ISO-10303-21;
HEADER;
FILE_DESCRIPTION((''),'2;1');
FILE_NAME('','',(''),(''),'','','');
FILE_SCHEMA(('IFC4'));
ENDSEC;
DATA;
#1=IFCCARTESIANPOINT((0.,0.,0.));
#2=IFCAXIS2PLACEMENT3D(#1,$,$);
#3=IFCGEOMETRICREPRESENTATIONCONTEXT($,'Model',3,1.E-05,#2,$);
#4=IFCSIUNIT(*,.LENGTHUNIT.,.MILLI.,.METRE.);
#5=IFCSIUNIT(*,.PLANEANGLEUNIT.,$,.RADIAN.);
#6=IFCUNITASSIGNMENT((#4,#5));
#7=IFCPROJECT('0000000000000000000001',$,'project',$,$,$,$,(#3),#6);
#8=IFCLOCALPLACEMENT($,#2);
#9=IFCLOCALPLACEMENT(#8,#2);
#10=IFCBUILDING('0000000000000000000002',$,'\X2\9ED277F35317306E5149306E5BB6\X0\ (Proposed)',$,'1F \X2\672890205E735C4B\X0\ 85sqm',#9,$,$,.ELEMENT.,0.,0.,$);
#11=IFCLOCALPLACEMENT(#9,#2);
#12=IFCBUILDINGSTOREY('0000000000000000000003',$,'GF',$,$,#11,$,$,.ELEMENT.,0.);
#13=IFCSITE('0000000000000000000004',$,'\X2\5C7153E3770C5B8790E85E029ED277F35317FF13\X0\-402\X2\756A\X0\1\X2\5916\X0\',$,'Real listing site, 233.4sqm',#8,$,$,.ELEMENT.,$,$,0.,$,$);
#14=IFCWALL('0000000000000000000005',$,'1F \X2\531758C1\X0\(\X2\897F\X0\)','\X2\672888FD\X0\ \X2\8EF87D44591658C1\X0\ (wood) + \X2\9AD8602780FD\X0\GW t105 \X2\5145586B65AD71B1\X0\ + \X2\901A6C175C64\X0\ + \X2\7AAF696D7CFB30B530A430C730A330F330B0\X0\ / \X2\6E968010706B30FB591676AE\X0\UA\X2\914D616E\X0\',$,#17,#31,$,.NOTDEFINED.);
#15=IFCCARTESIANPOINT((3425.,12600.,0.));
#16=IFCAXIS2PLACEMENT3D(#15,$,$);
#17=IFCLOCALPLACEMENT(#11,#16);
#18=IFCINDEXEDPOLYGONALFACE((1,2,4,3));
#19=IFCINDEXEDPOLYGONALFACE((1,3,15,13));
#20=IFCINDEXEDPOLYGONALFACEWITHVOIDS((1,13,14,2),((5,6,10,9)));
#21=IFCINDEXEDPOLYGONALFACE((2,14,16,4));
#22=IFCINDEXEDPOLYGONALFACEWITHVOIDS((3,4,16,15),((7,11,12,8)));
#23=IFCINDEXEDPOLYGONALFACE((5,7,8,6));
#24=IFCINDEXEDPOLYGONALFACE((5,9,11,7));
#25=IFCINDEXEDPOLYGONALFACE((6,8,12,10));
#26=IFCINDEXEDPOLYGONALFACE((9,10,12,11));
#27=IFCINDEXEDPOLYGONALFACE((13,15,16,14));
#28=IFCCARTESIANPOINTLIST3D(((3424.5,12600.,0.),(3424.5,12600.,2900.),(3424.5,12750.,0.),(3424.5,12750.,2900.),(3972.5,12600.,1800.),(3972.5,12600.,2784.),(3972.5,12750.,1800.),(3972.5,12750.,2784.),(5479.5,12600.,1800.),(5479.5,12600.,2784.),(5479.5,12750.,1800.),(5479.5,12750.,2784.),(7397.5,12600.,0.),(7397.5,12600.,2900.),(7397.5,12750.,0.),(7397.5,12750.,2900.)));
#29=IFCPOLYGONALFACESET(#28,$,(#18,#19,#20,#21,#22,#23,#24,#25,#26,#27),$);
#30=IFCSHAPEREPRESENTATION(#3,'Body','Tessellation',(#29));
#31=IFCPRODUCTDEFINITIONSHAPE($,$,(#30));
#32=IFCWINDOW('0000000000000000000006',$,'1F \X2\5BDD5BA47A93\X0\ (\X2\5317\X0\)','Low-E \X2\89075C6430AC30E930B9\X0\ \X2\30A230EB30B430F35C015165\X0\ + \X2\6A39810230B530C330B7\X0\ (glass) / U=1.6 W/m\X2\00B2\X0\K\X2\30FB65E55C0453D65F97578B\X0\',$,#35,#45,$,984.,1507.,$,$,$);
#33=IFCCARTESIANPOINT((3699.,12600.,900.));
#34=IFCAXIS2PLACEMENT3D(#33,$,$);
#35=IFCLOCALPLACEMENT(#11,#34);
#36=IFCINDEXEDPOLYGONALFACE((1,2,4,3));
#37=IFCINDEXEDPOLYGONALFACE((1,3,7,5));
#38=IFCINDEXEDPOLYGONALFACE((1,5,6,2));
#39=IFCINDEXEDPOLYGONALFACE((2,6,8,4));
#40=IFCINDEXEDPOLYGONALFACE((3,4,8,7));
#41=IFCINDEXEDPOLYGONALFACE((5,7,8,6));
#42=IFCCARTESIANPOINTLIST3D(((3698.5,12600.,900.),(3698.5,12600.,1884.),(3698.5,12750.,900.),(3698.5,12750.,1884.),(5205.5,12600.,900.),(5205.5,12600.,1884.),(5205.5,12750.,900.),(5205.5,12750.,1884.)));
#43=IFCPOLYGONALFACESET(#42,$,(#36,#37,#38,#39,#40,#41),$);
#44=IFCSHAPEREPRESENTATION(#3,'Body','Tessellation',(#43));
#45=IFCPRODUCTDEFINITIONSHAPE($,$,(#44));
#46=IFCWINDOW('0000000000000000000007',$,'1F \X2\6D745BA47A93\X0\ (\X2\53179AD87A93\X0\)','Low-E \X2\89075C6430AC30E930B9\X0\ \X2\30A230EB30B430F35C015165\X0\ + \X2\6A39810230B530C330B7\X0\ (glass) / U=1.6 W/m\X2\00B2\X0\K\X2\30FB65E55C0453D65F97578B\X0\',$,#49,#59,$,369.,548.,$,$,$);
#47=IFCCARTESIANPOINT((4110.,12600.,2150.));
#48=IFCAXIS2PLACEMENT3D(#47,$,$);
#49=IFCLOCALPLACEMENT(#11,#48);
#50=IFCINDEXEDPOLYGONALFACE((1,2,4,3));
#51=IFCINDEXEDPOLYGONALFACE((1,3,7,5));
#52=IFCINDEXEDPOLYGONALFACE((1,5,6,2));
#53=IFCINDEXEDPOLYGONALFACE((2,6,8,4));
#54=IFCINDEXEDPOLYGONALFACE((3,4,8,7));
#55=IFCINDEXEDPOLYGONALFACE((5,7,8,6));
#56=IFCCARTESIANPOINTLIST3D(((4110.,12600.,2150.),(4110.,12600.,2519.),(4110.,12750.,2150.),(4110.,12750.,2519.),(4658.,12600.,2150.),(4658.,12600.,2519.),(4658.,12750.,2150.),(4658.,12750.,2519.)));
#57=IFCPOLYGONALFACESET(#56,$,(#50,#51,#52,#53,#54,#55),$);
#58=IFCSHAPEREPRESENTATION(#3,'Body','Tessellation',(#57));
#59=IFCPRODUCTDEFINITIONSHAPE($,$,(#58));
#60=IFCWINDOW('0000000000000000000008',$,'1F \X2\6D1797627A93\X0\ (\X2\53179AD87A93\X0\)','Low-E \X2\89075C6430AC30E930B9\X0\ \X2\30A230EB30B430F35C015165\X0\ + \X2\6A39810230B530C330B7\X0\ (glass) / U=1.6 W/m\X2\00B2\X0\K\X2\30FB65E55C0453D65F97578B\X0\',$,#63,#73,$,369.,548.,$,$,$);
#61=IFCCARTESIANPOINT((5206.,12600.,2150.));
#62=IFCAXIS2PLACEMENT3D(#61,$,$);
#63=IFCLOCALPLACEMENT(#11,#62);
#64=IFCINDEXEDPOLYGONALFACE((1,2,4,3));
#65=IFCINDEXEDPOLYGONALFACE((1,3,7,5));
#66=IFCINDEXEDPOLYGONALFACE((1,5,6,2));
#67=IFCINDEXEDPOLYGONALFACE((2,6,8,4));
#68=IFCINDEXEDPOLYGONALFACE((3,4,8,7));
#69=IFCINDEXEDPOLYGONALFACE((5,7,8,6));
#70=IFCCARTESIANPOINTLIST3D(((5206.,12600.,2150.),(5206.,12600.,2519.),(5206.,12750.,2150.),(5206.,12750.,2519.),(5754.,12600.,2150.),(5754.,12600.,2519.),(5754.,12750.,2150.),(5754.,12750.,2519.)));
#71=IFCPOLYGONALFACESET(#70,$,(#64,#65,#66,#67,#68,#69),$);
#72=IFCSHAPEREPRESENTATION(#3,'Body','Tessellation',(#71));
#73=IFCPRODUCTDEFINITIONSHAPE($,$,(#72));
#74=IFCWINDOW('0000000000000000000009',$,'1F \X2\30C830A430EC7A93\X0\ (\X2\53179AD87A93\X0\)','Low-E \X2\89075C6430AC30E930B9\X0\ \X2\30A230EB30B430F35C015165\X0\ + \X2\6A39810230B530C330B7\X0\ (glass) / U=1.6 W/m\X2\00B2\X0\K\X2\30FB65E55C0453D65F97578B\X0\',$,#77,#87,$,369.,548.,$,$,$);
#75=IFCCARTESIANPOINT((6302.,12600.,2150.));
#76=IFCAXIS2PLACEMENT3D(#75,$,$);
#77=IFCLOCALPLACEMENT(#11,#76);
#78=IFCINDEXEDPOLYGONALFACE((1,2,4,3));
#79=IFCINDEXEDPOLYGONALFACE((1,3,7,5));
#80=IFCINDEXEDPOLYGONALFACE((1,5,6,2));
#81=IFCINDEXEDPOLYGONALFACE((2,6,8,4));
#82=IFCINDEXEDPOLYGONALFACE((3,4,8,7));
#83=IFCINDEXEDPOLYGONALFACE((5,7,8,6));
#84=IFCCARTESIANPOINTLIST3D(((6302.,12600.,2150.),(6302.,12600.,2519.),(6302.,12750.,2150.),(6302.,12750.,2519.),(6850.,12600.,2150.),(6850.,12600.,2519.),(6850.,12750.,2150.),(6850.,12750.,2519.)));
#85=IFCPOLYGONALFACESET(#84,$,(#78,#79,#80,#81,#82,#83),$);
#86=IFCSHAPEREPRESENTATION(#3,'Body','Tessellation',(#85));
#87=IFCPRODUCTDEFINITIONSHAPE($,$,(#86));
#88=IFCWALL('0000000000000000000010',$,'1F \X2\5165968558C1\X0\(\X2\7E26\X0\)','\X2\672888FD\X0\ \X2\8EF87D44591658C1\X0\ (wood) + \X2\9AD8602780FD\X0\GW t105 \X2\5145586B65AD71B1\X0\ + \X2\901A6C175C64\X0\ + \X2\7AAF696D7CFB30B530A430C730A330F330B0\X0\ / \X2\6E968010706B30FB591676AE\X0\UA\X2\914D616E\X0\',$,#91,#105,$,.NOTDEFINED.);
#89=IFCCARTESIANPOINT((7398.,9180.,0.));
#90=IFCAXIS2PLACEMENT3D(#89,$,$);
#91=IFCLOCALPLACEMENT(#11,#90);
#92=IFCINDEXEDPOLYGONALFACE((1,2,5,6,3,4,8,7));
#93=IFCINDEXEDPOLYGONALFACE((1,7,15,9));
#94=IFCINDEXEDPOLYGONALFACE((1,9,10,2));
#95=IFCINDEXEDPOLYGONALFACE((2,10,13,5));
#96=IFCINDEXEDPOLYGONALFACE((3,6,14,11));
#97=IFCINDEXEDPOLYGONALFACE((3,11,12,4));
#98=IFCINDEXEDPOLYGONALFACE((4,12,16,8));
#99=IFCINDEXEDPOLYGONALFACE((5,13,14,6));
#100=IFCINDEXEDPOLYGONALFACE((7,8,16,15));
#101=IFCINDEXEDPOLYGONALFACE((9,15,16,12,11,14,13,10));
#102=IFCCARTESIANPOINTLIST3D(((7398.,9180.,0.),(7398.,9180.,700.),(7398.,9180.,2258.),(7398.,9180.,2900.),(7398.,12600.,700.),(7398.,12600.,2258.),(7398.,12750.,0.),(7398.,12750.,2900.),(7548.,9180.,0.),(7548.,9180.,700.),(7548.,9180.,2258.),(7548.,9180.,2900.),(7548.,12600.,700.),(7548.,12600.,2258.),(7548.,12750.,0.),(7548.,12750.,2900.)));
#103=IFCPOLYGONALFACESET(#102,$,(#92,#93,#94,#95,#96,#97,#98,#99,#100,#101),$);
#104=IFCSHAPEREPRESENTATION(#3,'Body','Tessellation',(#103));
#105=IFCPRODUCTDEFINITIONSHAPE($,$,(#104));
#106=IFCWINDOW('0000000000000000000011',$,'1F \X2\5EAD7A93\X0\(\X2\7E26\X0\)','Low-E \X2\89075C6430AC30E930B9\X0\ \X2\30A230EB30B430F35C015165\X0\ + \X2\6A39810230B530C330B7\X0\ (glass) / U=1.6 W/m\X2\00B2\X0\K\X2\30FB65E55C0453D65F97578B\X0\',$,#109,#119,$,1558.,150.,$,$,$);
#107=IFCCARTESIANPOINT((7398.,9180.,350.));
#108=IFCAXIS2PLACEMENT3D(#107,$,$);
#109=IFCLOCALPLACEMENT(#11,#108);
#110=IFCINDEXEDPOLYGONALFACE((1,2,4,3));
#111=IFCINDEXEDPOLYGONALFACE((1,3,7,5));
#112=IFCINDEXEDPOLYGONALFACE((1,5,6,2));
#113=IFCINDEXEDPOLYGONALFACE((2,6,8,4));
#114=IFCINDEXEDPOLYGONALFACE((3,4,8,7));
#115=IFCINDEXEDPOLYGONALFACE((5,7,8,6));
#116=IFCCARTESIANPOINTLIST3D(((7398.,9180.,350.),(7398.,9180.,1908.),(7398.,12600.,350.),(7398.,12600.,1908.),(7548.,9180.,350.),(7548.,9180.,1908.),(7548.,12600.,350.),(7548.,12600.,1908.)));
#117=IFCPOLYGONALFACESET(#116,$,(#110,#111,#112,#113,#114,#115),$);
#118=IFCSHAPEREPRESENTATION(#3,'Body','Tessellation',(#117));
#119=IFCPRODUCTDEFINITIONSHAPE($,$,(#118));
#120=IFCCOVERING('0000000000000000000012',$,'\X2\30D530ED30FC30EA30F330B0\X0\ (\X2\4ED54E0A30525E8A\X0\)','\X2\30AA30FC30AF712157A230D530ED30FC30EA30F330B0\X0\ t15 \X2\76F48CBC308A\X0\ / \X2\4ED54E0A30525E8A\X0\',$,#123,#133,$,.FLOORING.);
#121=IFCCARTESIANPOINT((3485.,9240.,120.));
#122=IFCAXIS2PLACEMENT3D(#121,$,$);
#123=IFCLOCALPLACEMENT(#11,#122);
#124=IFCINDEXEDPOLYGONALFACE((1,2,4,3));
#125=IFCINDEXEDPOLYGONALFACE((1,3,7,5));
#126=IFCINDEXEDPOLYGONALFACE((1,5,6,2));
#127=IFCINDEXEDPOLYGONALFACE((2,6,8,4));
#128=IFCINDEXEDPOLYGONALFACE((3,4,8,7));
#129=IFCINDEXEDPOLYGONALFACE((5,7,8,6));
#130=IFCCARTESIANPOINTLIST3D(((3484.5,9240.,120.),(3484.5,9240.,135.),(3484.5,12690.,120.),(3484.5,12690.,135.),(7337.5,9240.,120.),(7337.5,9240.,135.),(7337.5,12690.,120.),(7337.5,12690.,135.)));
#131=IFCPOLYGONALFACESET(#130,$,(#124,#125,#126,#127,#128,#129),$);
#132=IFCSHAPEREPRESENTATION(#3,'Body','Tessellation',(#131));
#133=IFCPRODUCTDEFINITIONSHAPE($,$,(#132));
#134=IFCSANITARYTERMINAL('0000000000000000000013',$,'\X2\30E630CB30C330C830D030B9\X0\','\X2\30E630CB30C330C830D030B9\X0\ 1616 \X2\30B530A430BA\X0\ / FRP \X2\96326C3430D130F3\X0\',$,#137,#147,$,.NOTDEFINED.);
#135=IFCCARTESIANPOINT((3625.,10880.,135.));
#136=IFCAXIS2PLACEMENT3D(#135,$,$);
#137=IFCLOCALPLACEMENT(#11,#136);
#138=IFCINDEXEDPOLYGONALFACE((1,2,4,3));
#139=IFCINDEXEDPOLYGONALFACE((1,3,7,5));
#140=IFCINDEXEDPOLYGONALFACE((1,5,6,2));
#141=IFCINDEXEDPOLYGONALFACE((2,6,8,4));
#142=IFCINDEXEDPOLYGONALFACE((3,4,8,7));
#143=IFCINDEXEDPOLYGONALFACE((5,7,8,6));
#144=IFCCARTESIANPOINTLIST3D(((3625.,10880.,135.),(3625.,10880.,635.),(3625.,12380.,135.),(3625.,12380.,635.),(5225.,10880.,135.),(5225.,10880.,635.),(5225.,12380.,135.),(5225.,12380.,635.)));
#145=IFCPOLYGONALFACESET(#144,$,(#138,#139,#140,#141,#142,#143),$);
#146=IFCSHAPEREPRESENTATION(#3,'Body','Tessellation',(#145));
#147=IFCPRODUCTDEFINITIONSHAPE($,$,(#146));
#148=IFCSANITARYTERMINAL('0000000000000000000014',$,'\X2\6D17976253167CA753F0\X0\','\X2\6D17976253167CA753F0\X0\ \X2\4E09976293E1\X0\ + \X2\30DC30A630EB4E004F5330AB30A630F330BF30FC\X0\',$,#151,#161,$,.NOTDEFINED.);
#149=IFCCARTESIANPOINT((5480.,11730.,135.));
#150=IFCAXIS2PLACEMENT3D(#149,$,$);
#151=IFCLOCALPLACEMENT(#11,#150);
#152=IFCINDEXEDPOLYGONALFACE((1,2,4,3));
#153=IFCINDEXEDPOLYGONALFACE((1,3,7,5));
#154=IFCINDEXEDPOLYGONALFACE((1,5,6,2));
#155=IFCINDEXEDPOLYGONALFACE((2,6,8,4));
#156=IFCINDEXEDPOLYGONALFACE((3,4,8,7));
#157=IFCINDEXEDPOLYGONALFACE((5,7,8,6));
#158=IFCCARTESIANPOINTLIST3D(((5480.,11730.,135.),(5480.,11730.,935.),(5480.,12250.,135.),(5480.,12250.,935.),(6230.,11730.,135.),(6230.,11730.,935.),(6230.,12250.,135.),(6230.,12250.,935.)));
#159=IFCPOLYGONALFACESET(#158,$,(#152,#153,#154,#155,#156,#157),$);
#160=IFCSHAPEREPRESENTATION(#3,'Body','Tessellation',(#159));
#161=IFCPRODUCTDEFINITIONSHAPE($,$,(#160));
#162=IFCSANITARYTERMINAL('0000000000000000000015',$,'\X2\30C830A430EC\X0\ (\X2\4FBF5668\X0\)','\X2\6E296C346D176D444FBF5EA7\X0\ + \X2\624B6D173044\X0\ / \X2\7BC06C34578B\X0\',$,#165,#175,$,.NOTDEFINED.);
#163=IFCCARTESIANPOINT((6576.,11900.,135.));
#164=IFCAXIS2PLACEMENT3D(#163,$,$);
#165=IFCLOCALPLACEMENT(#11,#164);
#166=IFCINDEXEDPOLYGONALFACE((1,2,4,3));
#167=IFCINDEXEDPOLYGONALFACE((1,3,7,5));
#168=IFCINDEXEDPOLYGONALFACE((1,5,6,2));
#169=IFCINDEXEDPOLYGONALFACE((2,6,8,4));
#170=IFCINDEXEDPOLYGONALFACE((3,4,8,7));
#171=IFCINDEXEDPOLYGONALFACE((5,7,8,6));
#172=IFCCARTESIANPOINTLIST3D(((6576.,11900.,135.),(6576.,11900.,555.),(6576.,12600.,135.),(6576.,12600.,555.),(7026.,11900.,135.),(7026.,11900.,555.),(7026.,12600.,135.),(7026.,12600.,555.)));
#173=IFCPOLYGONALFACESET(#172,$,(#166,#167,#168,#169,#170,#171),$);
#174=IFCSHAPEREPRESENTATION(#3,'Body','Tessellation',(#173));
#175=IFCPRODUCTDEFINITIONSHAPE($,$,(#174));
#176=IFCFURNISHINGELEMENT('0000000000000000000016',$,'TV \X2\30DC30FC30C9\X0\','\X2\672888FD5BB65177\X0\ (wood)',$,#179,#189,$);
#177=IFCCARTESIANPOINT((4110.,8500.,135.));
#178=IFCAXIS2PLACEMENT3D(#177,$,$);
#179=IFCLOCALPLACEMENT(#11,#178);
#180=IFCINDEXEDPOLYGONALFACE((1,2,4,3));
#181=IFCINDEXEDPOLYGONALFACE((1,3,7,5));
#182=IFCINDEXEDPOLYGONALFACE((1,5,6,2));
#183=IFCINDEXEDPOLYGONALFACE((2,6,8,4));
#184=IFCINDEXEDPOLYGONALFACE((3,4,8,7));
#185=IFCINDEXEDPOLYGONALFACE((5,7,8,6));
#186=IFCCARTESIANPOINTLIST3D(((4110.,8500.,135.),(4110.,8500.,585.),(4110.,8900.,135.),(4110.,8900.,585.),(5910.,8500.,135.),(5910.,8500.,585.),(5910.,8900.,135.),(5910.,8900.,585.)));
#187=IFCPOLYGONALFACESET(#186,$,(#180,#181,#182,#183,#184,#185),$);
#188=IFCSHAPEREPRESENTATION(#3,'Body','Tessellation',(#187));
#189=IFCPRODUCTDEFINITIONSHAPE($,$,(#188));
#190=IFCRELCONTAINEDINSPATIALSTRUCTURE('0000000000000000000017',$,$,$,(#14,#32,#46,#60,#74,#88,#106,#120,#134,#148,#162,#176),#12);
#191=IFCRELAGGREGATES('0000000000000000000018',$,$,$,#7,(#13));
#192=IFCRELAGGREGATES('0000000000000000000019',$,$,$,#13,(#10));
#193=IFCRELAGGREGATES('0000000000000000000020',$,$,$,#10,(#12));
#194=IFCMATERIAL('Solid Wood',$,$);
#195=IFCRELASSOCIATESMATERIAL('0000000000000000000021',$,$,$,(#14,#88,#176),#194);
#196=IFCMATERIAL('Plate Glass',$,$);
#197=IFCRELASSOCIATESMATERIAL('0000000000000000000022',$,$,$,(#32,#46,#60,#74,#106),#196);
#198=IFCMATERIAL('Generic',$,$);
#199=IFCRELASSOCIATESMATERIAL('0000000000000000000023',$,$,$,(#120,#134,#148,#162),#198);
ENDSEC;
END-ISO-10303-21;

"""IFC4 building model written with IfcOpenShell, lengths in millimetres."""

from ifc_helpers import new_model, si_unit, frame, frame_2d, origin, place, context, project, spatial, rectangle, extrude, material, element, fill, save


model = new_model("IFC4")

# Units and contexts
model_context = context("Model", 3, precision=1e-05, world=origin())
ifc_project = project(units=[si_unit("LENGTHUNIT", "METRE", prefix="MILLI"), si_unit("PLANEANGLEUNIT", "RADIAN")], contexts=[model_context])

# Site, building, storey
site_placement = place(None, origin())
site = spatial("IfcSite", under=ifc_project, at=site_placement, Name="山口県宇部市黒石北３-402番1外", ObjectType="Real listing site, 233.4sqm", CompositionType="ELEMENT", RefElevation=0.0)
building_placement = place(site_placement, origin())
building = spatial("IfcBuilding", under=site, at=building_placement, Name="黒石北の光の家 (Proposed)", ObjectType="1F 木造平屋 85sqm", CompositionType="ELEMENT", ElevationOfRefHeight=0.0, ElevationOfTerrain=0.0)
storey_placement = place(building_placement, origin())
storey = spatial("IfcBuildingStorey", under=building, at=storey_placement, Name="GF", CompositionType="ELEMENT", Elevation=0.0)

# Shared definitions
ifc_material_1 = material(Name="Solid Wood")

# Wall, openings, windows
wall_1_placement = place(storey_placement, frame((3425.0, 12600.0, 0.0)))
wall_1 = element("IfcWall", 1, at=wall_1_placement, inside=storey, material=ifc_material_1, Name="1F 北壁(西)", Description="木製 軸組外壁 (wood) + 高性能GW t105 充填断熱 + 通気層 + 窯業系サイディング / 準耐火・外皮UA配慮", PredefinedType="NOTDEFINED", context=model_context, shape_type="SweptSolid", body=[
    extrude(rectangle(XDim=3973.0, YDim=150.0, at=frame_2d((1986.0, 75.0))), frame((3425.0, 12600.0, 0.0)), (0.0, 0.0, 1.0), 2900.0),
])
opening_1_placement = place(storey_placement, frame((3699.0, 12600.0, 900.0)))
opening_1 = element("IfcOpeningElement", 2, at=opening_1_placement, cuts=wall_1, PredefinedType="NOTDEFINED", context=model_context, shape_type="SweptSolid", body=[
    extrude(rectangle(XDim=1507.0, YDim=150.0, at=frame_2d((753.0, 75.0))), frame((3699.0, 12600.0, 900.0)), (0.0, 0.0, 1.0), 984.0),
])
opening_2_placement = place(storey_placement, frame((4110.0, 12600.0, 2150.0)))
opening_2 = element("IfcOpeningElement", 3, at=opening_2_placement, cuts=wall_1, PredefinedType="NOTDEFINED", context=model_context, shape_type="SweptSolid", body=[
    extrude(rectangle(XDim=548.0, YDim=150.0, at=frame_2d((274.0, 75.0))), frame((4110.0, 12600.0, 2150.0)), (0.0, 0.0, 1.0), 369.0),
])
opening_3_placement = place(storey_placement, frame((5206.0, 12600.0, 2150.0)))
opening_3 = element("IfcOpeningElement", 4, at=opening_3_placement, cuts=wall_1, PredefinedType="NOTDEFINED", context=model_context, shape_type="SweptSolid", body=[
    extrude(rectangle(XDim=548.0, YDim=150.0, at=frame_2d((274.0, 75.0))), frame((5206.0, 12600.0, 2150.0)), (0.0, 0.0, 1.0), 369.0),
])
opening_4_placement = place(storey_placement, frame((6302.0, 12600.0, 2150.0)))
opening_4 = element("IfcOpeningElement", 5, at=opening_4_placement, cuts=wall_1, PredefinedType="NOTDEFINED", context=model_context, shape_type="SweptSolid", body=[
    extrude(rectangle(XDim=548.0, YDim=150.0, at=frame_2d((274.0, 75.0))), frame((6302.0, 12600.0, 2150.0)), (0.0, 0.0, 1.0), 369.0),
])
ifc_material_2 = material(Name="Plate Glass")
window_1_placement = place(storey_placement, frame((3699.0, 12600.0, 900.0)))
window_1 = element("IfcWindow", 6, at=window_1_placement, inside=storey, material=ifc_material_2, Name="1F 寝室窓 (北)", Description="Low-E 複層ガラス アルゴン封入 + 樹脂サッシ (glass) / U=1.6 W/m²K・日射取得型", OverallHeight=984.0, OverallWidth=1507.0, context=model_context, shape_type="SweptSolid", body=[
    extrude(rectangle(XDim=1507.0, YDim=150.0, at=frame_2d((753.0, 75.0))), frame((3699.0, 12600.0, 900.0)), (0.0, 0.0, 1.0), 984.0),
])
fill(opening_1, window_1)
window_2_placement = place(storey_placement, frame((4110.0, 12600.0, 2150.0)))
window_2 = element("IfcWindow", 7, at=window_2_placement, inside=storey, material=ifc_material_2, Name="1F 浴室窓 (北高窓)", Description="Low-E 複層ガラス アルゴン封入 + 樹脂サッシ (glass) / U=1.6 W/m²K・日射取得型", OverallHeight=369.0, OverallWidth=548.0, context=model_context, shape_type="SweptSolid", body=[
    extrude(rectangle(XDim=548.0, YDim=150.0, at=frame_2d((274.0, 75.0))), frame((4110.0, 12600.0, 2150.0)), (0.0, 0.0, 1.0), 369.0),
])
fill(opening_2, window_2)
window_3_placement = place(storey_placement, frame((5206.0, 12600.0, 2150.0)))
window_3 = element("IfcWindow", 8, at=window_3_placement, inside=storey, material=ifc_material_2, Name="1F 洗面窓 (北高窓)", Description="Low-E 複層ガラス アルゴン封入 + 樹脂サッシ (glass) / U=1.6 W/m²K・日射取得型", OverallHeight=369.0, OverallWidth=548.0, context=model_context, shape_type="SweptSolid", body=[
    extrude(rectangle(XDim=548.0, YDim=150.0, at=frame_2d((274.0, 75.0))), frame((5206.0, 12600.0, 2150.0)), (0.0, 0.0, 1.0), 369.0),
])
fill(opening_3, window_3)
window_4_placement = place(storey_placement, frame((6302.0, 12600.0, 2150.0)))
window_4 = element("IfcWindow", 9, at=window_4_placement, inside=storey, material=ifc_material_2, Name="1F トイレ窓 (北高窓)", Description="Low-E 複層ガラス アルゴン封入 + 樹脂サッシ (glass) / U=1.6 W/m²K・日射取得型", OverallHeight=369.0, OverallWidth=548.0, context=model_context, shape_type="SweptSolid", body=[
    extrude(rectangle(XDim=548.0, YDim=150.0, at=frame_2d((274.0, 75.0))), frame((6302.0, 12600.0, 2150.0)), (0.0, 0.0, 1.0), 369.0),
])
fill(opening_4, window_4)

# Wall, opening, window
wall_2_placement = place(storey_placement, frame((7398.0, 9180.0, 0.0)))
wall_2 = element("IfcWall", 10, at=wall_2_placement, inside=storey, material=ifc_material_1, Name="1F 入隅壁(縦)", Description="木製 軸組外壁 (wood) + 高性能GW t105 充填断熱 + 通気層 + 窯業系サイディング / 準耐火・外皮UA配慮", PredefinedType="NOTDEFINED", context=model_context, shape_type="SweptSolid", body=[
    extrude(rectangle(XDim=150.0, YDim=3570.0, at=frame_2d((75.0, 1785.0))), frame((7398.0, 9180.0, 0.0)), (0.0, 0.0, 1.0), 2900.0),
])
opening_5_placement = place(storey_placement, frame((7398.0, 9180.0, 350.0)))
opening_5 = element("IfcOpeningElement", 11, at=opening_5_placement, cuts=wall_2, PredefinedType="NOTDEFINED", context=model_context, shape_type="SweptSolid", body=[
    extrude(rectangle(XDim=150.0, YDim=3420.0, at=frame_2d((75.0, 1710.0))), frame((7398.0, 9180.0, 350.0)), (0.0, 0.0, 1.0), 1558.0),
])
window_5_placement = place(storey_placement, frame((7398.0, 9180.0, 350.0)))
window_5 = element("IfcWindow", 12, at=window_5_placement, inside=storey, material=ifc_material_2, Name="1F 庭窓(縦)", Description="Low-E 複層ガラス アルゴン封入 + 樹脂サッシ (glass) / U=1.6 W/m²K・日射取得型", OverallHeight=1558.0, OverallWidth=150.0, context=model_context, shape_type="SweptSolid", body=[
    extrude(rectangle(XDim=150.0, YDim=3420.0, at=frame_2d((75.0, 1710.0))), frame((7398.0, 9180.0, 350.0)), (0.0, 0.0, 1.0), 1558.0),
])
fill(opening_5, window_5)

# Covering
ifc_material_3 = material(Name="Generic")
covering_placement = place(storey_placement, frame((3485.0, 9240.0, 120.0)))
element("IfcCovering", 13, at=covering_placement, inside=storey, material=ifc_material_3, Name="フローリング (仕上げ床)", Description="オーク無垢フローリング t15 直貼り / 仕上げ床", PredefinedType="FLOORING", context=model_context, shape_type="SweptSolid", body=[
    extrude(rectangle(XDim=3853.0, YDim=3450.0, at=frame_2d((1926.0, 1725.0))), frame((3485.0, 9240.0, 120.0)), (0.0, 0.0, 1.0), 15.0),
])

# Sanitary terminals
sanitary_terminal_1_placement = place(storey_placement, frame((3625.0, 10880.0, 135.0)))
element("IfcSanitaryTerminal", 14, at=sanitary_terminal_1_placement, inside=storey, material=ifc_material_3, Name="ユニットバス", Description="ユニットバス 1616 サイズ / FRP 防水パン", PredefinedType="NOTDEFINED", context=model_context, shape_type="SweptSolid", body=[
    extrude(rectangle(XDim=1600.0, YDim=1500.0, at=frame_2d((800.0, 750.0))), frame((3625.0, 10880.0, 135.0)), (0.0, 0.0, 1.0), 500.0),
])
sanitary_terminal_2_placement = place(storey_placement, frame((5480.0, 11730.0, 135.0)))
element("IfcSanitaryTerminal", 15, at=sanitary_terminal_2_placement, inside=storey, material=ifc_material_3, Name="洗面化粧台", Description="洗面化粧台 三面鏡 + ボウル一体カウンター", PredefinedType="NOTDEFINED", context=model_context, shape_type="SweptSolid", body=[
    extrude(rectangle(XDim=750.0, YDim=520.0, at=frame_2d((375.0, 260.0))), frame((5480.0, 11730.0, 135.0)), (0.0, 0.0, 1.0), 800.0),
])
sanitary_terminal_3_placement = place(storey_placement, frame((6576.0, 11900.0, 135.0)))
element("IfcSanitaryTerminal", 16, at=sanitary_terminal_3_placement, inside=storey, material=ifc_material_3, Name="トイレ (便器)", Description="温水洗浄便座 + 手洗い / 節水型", PredefinedType="NOTDEFINED", context=model_context, shape_type="SweptSolid", body=[
    extrude(rectangle(XDim=450.0, YDim=700.0, at=frame_2d((225.0, 350.0))), frame((6576.0, 11900.0, 135.0)), (0.0, 0.0, 1.0), 420.0),
])

# Furnishing element
furnishing_placement = place(storey_placement, frame((4110.0, 8500.0, 135.0)))
element("IfcFurnishingElement", 17, at=furnishing_placement, inside=storey, material=ifc_material_1, Name="TV ボード", Description="木製家具 (wood)", context=model_context, shape_type="SweptSolid", body=[
    extrude(rectangle(XDim=1800.0, YDim=400.0, at=frame_2d((900.0, 200.0))), frame((4110.0, 8500.0, 135.0)), (0.0, 0.0, 1.0), 450.0),
])

save(model, "model.ifc")
